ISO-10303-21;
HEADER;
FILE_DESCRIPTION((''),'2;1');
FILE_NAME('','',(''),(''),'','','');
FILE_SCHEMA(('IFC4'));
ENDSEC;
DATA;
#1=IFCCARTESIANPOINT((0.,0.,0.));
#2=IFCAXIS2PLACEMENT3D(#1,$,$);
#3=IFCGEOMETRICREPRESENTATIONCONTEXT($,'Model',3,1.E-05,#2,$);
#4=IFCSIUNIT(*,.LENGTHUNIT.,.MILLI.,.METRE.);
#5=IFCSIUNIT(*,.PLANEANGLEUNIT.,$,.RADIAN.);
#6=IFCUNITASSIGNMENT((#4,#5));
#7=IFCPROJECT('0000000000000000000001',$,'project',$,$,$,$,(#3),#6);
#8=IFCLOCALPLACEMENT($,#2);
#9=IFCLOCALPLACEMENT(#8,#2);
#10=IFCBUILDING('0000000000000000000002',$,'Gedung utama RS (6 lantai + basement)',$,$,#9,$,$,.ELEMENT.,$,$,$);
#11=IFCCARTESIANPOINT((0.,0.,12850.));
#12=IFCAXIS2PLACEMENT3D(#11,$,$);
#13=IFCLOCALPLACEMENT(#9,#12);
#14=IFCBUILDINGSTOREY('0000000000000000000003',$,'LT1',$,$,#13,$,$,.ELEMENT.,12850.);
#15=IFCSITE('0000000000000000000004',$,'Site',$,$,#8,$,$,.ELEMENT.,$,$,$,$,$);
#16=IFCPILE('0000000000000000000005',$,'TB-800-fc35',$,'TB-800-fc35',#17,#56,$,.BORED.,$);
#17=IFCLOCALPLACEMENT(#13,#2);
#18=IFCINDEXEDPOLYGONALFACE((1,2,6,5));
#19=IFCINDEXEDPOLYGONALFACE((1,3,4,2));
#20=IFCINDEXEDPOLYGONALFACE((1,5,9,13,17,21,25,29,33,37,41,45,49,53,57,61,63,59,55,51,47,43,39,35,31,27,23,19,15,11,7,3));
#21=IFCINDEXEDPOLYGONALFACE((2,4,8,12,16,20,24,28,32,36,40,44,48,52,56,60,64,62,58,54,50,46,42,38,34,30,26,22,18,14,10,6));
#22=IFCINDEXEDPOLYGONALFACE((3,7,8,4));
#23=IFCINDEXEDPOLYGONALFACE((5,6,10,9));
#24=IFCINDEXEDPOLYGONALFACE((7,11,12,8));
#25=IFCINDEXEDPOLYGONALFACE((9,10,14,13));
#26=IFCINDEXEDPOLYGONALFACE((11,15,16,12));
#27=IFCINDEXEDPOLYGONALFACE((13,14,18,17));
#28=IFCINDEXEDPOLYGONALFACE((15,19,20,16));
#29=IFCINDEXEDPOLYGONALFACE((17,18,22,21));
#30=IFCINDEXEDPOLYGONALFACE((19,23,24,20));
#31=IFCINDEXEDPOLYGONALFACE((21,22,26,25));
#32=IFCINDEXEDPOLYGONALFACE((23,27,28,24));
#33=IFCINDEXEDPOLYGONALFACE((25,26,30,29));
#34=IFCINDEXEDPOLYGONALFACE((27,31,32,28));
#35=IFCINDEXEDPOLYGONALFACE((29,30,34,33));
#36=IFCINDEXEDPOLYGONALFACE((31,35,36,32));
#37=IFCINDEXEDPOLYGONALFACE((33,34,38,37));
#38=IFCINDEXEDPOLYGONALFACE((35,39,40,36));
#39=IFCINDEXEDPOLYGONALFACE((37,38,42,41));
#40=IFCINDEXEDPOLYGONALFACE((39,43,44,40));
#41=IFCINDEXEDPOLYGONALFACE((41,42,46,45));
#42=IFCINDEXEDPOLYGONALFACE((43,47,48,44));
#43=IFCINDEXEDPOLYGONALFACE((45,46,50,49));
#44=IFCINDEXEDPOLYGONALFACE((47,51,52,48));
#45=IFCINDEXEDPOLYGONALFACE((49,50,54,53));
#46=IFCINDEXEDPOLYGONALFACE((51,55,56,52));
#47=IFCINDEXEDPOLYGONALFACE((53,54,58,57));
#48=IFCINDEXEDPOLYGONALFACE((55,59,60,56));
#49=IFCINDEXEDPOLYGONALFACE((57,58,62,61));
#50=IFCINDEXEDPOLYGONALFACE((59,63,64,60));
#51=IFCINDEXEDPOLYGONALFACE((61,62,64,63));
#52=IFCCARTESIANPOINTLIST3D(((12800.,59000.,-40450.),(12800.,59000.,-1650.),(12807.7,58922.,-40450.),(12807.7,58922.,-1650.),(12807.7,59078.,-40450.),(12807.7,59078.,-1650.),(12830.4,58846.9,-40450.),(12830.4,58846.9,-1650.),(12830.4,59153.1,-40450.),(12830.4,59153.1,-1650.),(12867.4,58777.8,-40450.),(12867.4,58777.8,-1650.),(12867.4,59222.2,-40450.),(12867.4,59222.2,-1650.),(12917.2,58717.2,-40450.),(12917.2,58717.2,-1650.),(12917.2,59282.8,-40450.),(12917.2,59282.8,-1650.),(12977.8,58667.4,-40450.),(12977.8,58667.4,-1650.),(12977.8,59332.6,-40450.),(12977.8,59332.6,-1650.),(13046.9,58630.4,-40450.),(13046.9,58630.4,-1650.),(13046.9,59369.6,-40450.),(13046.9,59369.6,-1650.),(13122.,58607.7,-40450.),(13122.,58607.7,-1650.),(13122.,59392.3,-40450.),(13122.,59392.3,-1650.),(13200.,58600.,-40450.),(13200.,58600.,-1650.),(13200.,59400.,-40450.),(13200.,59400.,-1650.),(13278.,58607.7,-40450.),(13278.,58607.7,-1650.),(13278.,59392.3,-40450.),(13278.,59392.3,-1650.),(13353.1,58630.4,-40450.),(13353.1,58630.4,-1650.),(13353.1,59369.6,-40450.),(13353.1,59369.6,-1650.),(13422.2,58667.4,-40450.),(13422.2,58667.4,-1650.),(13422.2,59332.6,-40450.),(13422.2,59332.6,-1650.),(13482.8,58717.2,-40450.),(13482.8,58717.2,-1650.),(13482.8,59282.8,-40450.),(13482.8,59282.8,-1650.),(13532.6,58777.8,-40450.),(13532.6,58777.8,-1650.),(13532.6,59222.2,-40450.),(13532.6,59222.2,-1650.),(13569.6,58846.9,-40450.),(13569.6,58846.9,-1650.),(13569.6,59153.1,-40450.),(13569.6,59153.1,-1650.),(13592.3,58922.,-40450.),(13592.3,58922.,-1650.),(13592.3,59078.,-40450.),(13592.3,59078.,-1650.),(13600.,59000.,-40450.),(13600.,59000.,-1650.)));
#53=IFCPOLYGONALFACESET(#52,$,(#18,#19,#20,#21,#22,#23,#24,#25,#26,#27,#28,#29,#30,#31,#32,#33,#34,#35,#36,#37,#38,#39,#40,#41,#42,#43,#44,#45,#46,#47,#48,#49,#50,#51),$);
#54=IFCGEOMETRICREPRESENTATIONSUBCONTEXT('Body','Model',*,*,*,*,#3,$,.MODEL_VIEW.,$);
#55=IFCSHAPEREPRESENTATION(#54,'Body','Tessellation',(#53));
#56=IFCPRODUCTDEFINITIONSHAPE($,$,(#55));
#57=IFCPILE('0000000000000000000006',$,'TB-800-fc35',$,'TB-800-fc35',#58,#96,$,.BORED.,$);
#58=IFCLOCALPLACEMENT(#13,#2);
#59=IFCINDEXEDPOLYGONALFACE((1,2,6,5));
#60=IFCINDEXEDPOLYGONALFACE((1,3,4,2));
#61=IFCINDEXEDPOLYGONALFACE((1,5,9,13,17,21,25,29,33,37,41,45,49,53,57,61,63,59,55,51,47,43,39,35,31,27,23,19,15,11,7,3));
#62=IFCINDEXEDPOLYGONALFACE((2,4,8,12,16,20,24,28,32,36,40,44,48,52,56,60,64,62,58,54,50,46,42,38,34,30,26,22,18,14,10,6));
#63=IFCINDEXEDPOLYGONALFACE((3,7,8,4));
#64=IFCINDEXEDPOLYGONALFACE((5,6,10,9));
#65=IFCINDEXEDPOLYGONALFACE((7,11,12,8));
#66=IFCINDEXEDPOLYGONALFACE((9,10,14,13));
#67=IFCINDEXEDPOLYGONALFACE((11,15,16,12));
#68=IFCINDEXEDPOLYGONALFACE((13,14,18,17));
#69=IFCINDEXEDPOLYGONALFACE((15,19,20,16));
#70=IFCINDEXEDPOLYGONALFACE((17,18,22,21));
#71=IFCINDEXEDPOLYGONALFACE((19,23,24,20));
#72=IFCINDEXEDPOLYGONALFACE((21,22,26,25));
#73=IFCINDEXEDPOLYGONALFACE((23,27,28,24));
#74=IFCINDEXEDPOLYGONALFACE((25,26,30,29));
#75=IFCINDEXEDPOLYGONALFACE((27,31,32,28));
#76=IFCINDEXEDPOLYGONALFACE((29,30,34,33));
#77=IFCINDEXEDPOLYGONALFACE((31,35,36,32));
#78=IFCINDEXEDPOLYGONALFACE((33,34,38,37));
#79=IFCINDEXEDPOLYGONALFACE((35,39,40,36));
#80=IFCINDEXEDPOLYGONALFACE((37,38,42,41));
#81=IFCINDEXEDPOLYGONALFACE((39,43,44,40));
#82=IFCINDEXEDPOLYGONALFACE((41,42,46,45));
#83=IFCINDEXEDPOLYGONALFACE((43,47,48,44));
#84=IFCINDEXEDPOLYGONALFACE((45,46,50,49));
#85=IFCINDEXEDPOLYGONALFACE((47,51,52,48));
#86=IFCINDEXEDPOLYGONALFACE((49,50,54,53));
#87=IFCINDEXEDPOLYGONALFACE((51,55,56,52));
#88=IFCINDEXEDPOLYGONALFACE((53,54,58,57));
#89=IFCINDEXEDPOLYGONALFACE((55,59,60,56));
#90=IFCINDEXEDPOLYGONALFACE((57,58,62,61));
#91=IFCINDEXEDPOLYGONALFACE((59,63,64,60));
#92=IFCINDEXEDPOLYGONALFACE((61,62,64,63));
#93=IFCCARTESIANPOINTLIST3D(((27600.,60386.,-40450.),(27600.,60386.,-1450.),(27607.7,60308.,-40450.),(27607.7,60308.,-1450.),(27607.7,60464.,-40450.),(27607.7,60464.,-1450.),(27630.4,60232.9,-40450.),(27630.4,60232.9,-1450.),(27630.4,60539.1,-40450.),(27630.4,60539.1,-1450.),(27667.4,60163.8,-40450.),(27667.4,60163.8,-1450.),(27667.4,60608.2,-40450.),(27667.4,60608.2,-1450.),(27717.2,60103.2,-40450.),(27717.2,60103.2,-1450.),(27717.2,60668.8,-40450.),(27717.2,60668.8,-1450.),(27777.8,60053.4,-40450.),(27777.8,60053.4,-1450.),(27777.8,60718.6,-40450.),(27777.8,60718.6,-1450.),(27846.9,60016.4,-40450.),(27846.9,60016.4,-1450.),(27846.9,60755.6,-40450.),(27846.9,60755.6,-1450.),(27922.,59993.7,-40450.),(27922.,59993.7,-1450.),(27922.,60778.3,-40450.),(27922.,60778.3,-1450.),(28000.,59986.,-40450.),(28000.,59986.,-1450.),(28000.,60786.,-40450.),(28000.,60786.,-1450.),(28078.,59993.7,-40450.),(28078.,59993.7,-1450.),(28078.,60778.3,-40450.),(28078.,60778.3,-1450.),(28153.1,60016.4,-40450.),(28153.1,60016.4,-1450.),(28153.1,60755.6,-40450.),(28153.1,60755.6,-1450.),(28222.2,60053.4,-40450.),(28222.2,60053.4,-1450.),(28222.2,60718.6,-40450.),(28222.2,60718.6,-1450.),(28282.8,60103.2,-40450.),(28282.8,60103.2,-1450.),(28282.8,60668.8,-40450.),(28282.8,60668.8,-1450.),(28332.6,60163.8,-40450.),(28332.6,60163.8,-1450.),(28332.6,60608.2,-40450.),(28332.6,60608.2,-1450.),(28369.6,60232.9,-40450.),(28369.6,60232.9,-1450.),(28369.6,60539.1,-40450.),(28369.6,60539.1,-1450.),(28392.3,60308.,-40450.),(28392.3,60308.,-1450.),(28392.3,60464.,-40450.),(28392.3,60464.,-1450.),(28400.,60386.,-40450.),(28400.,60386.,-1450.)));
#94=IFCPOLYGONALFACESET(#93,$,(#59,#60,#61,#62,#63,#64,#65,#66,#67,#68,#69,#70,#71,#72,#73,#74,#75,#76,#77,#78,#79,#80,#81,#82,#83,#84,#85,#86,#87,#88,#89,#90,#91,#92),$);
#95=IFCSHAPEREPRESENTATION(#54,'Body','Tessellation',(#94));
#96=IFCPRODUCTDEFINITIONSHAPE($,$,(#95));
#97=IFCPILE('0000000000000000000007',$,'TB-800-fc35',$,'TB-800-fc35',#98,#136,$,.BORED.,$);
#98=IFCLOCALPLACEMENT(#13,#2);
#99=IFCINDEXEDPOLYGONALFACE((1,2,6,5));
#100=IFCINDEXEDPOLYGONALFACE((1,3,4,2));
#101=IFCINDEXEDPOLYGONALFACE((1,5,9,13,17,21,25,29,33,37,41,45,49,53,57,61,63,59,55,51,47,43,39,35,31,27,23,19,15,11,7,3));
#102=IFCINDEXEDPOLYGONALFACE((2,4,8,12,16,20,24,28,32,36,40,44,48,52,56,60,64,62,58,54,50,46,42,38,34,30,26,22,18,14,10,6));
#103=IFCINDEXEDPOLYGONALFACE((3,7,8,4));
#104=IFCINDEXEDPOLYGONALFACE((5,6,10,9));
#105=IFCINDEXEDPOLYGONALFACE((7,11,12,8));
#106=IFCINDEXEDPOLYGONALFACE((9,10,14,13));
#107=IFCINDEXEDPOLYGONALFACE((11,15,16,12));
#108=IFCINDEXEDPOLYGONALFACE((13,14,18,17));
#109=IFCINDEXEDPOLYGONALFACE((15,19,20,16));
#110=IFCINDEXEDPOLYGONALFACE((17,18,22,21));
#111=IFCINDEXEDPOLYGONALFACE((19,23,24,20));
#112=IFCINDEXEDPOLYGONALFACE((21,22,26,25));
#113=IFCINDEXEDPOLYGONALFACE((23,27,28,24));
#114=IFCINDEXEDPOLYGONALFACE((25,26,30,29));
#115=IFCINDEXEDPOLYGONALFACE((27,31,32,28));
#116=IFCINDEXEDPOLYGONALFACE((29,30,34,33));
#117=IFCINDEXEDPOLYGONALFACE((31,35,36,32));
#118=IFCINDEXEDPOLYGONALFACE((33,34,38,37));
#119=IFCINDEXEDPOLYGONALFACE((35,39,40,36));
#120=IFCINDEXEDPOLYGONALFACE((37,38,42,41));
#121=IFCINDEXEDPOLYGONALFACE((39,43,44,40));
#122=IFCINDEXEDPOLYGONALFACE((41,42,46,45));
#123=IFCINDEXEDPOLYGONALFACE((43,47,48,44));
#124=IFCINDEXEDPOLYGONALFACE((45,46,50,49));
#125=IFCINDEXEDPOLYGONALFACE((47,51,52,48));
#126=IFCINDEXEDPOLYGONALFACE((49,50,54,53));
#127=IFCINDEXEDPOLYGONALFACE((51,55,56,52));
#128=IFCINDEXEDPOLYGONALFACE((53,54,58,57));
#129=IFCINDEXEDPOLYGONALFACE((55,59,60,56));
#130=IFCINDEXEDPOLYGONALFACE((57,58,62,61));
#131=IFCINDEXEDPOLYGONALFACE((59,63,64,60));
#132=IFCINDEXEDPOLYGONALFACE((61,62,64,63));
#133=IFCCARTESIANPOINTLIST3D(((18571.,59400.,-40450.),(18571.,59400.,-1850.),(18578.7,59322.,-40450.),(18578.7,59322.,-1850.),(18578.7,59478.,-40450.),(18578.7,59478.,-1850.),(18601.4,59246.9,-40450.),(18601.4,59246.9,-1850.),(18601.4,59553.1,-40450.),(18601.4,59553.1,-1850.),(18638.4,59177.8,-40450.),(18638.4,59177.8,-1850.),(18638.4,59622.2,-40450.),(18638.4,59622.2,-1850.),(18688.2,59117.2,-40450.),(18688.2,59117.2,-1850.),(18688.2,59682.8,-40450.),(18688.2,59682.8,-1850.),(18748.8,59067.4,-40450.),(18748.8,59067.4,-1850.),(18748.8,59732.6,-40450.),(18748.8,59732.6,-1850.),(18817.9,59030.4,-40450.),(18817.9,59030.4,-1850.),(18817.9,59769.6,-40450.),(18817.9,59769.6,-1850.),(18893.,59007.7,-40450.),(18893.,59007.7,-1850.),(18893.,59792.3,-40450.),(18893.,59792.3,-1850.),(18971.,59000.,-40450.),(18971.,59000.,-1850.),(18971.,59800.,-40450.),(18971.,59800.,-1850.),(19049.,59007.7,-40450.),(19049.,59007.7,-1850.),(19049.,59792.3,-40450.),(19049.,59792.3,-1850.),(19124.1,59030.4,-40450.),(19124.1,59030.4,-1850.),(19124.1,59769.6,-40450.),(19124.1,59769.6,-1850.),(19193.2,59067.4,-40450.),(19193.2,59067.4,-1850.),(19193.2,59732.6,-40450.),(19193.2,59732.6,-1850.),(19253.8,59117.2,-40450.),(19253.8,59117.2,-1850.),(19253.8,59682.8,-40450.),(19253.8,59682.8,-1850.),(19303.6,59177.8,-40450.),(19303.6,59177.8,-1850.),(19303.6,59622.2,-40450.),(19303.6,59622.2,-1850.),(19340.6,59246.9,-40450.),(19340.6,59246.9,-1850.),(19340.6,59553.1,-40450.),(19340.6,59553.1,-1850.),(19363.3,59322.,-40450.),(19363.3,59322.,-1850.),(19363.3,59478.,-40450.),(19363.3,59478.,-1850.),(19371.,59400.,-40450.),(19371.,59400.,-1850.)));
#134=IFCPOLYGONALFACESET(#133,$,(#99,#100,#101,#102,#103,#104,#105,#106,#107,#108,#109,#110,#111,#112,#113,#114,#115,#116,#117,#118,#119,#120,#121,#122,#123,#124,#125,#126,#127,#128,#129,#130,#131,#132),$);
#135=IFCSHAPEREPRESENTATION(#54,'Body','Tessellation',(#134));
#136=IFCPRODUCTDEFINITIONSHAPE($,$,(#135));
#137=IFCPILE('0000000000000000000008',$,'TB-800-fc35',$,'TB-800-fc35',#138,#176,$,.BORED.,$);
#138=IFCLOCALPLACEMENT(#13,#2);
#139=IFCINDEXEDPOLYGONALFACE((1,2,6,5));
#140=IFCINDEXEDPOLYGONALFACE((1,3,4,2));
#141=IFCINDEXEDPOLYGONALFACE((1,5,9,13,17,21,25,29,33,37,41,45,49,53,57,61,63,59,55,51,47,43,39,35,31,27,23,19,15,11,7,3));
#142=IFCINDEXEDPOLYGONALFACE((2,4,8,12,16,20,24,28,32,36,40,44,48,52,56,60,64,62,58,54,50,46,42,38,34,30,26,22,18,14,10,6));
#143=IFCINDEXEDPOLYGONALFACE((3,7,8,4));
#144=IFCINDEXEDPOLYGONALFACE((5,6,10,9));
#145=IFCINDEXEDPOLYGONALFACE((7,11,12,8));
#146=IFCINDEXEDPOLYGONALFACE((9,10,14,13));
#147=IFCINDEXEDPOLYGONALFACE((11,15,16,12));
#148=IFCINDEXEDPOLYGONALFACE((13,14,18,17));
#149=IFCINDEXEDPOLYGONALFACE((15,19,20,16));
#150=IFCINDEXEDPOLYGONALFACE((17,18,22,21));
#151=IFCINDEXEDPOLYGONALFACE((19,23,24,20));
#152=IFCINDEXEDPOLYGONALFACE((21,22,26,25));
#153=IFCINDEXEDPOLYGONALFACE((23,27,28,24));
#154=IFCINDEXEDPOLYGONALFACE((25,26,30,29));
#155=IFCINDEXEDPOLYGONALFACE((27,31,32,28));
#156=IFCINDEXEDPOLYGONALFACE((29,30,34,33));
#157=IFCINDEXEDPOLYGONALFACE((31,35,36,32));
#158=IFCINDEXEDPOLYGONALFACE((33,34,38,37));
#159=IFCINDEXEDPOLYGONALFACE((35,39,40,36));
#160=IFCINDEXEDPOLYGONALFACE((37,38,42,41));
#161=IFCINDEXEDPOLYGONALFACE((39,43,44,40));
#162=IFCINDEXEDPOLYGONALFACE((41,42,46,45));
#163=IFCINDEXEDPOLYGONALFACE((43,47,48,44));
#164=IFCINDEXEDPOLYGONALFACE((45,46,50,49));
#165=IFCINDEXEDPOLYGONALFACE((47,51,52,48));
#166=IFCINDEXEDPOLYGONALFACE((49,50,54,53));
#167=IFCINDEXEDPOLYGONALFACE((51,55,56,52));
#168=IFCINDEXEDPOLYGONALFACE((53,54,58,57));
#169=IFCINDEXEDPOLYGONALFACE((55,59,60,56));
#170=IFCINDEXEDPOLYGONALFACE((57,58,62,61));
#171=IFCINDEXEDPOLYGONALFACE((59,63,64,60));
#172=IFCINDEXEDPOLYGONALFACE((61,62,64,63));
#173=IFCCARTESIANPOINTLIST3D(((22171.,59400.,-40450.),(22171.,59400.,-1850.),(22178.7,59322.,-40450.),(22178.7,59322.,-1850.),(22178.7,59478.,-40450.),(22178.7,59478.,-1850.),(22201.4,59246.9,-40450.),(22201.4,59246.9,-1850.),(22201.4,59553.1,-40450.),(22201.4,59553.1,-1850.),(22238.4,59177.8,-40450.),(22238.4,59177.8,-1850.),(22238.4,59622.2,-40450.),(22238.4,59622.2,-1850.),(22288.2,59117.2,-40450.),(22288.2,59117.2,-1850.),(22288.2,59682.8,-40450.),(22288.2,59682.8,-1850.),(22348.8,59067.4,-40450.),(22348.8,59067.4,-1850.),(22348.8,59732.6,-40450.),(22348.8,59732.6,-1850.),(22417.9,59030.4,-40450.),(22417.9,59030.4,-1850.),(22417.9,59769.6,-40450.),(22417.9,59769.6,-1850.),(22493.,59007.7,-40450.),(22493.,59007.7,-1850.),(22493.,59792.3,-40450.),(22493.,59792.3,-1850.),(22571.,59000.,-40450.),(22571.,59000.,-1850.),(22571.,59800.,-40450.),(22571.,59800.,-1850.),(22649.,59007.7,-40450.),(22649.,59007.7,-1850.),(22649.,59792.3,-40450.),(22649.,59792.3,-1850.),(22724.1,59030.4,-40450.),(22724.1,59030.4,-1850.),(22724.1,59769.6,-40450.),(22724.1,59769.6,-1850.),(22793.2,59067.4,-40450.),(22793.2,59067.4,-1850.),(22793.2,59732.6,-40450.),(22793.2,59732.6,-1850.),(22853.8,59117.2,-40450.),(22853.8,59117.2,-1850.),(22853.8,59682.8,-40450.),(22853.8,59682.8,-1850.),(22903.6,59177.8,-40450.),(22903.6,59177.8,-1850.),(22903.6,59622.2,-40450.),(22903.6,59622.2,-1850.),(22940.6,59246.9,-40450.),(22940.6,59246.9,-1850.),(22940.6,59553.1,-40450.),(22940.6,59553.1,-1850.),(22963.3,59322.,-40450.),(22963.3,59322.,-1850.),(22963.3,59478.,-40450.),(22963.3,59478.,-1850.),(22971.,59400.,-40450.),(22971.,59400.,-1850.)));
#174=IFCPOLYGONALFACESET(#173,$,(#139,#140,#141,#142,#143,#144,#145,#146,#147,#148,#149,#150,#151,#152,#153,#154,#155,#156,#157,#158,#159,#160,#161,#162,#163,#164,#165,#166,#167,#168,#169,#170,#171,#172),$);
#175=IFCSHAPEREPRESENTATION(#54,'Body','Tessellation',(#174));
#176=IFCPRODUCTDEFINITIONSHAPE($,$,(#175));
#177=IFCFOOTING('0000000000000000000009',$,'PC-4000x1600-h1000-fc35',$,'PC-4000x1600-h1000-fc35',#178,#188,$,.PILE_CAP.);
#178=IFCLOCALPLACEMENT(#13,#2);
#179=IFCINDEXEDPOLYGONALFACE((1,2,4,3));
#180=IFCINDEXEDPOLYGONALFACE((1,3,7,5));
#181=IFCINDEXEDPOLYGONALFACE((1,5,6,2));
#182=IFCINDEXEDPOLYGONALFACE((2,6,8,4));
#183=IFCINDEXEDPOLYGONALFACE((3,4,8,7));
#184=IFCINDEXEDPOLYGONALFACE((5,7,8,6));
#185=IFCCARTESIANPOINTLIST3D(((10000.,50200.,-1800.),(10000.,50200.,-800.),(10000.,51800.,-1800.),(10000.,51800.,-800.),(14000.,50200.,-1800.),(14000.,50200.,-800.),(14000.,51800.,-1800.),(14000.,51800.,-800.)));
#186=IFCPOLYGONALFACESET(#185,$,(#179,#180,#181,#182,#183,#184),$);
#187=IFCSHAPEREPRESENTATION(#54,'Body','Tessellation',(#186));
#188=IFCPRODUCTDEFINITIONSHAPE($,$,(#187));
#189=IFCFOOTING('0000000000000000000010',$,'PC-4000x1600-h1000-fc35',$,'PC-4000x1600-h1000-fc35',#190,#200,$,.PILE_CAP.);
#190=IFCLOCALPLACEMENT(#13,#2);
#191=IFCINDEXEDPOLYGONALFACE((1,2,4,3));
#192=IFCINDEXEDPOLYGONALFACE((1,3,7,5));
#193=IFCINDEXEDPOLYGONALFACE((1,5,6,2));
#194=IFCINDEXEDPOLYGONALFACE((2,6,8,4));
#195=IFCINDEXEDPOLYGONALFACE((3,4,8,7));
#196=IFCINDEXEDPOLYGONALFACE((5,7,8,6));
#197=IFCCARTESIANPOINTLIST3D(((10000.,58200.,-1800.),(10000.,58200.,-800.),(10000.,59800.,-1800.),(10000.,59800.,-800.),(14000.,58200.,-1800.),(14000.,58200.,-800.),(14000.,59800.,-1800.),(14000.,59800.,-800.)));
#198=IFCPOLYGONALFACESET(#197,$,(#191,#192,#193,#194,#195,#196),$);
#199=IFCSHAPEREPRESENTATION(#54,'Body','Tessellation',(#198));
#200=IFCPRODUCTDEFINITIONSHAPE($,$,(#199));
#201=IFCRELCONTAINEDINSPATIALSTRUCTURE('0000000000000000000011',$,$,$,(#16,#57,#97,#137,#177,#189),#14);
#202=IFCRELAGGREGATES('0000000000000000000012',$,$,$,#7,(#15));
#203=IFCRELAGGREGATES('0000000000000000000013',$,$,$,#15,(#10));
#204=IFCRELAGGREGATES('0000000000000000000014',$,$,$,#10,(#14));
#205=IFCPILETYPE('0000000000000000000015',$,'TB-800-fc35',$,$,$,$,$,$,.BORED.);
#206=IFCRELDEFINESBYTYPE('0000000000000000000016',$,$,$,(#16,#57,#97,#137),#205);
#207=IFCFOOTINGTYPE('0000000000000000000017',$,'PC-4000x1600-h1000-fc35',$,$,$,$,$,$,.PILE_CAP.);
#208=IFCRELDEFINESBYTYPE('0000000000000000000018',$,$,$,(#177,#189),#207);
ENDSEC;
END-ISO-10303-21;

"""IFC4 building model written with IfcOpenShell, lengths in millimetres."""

from ifc_helpers import new_model, si_unit, frame, origin, origin_2d, place, context, subcontext, project, spatial, rectangle, circle, extrude, material_profile, profile_set, profile_usage, type_object, element, save


model = new_model("IFC4")

# Units and contexts
model_context = context("Model", 3, precision=1e-05, world=origin())
body_context = subcontext(model_context, "Body", "Model", "MODEL_VIEW")
ifc_project = project(units=[si_unit("LENGTHUNIT", "METRE", prefix="MILLI"), si_unit("PLANEANGLEUNIT", "RADIAN")], contexts=[model_context])

# Site, building, storey
site_placement = place(None, origin())
site = spatial("IfcSite", under=ifc_project, at=site_placement, Name="Site", CompositionType="ELEMENT")
building_placement = place(site_placement, origin())
building = spatial("IfcBuilding", under=site, at=building_placement, Name="Gedung utama RS (6 lantai + basement)", CompositionType="ELEMENT")
storey_placement = place(building_placement, frame((0.0, 0.0, 12850.0)))
storey = spatial("IfcBuildingStorey", under=building, at=storey_placement, Name="LT1", CompositionType="ELEMENT", Elevation=12850.0)

# Piles
ifc_material_profile_1 = material_profile(None, circle(Radius=400.0, at=origin_2d()), Name="TB-800-fc35")
ifc_profile_set_1 = profile_set([ifc_material_profile_1], Name="TB-800-fc35")
ifc_profile_usage_1 = profile_usage(ifc_profile_set_1, cardinal=5)
pile_type = type_object("IfcPileType", Name="TB-800-fc35", PredefinedType="BORED")
pile_1_placement = place(storey_placement, frame((13200.0, 59000.0, -40450.0), z_axis=(0.0, 0.0, 1.0), x_axis=(1.0, 0.0, 0.0)))
element("IfcPile", 1, at=pile_1_placement, inside=storey, type_object=pile_type, material=ifc_profile_usage_1, Name="TB-800-fc35", ObjectType="TB-800-fc35", PredefinedType="BORED", context=body_context, shape_type="SweptSolid", body=[
    extrude(circle(Radius=400.0, at=origin_2d()), origin(), (0.0, 0.0, 1.0), 38800.0),
])
pile_2_placement = place(storey_placement, frame((28000.0, 60386.0, -40450.0), z_axis=(0.0, 0.0, 1.0), x_axis=(1.0, 0.0, 0.0)))
element("IfcPile", 2, at=pile_2_placement, inside=storey, type_object=pile_type, material=ifc_profile_usage_1, Name="TB-800-fc35", ObjectType="TB-800-fc35", PredefinedType="BORED", context=body_context, shape_type="SweptSolid", body=[
    extrude(circle(Radius=400.0, at=origin_2d()), origin(), (0.0, 0.0, 1.0), 39000.0),
])
for number, where, z_axis, x_axis, name in (
    (3, (18971.0, 59400.0, -40450.0), (0.0, 0.0, 1.0), (1.0, 0.0, 0.0), "TB-800-fc35"),
    (4, (22571.0, 59400.0, -40450.0), (0.0, 0.0, 1.0), (1.0, 0.0, 0.0), "TB-800-fc35"),
):
    element("IfcPile", number, at=place(storey_placement, frame(where, z_axis=z_axis, x_axis=x_axis)), inside=storey, type_object=pile_type, material=ifc_profile_usage_1, Name=name, ObjectType="TB-800-fc35", PredefinedType="BORED", context=body_context, shape_type="SweptSolid", body=[
        extrude(circle(Radius=400.0, at=origin_2d()), origin(), (0.0, 0.0, 1.0), 38600.0),
    ])

# Footings
ifc_material_profile_2 = material_profile(None, rectangle(XDim=4000.0, YDim=1600.0, at=origin_2d()), Name="PC-4000x1600-h1000-fc35")
ifc_profile_set_2 = profile_set([ifc_material_profile_2], Name="PC-4000x1600-h1000-fc35")
ifc_profile_usage_2 = profile_usage(ifc_profile_set_2, cardinal=5)
footing_type_1 = type_object("IfcFootingType", Name="PC-4000x1600-h1000-fc35", PredefinedType="PILE_CAP")
for number, where, z_axis, x_axis, name in (
    (5, (12000.0, 51000.0, -1800.0), (0.0, 0.0, 1.0), (1.0, 0.0, 0.0), "PC-4000x1600-h1000-fc35"),
    (6, (12000.0, 59000.0, -1800.0), (0.0, 0.0, 1.0), (1.0, 0.0, 0.0), "PC-4000x1600-h1000-fc35"),
):
    element("IfcFooting", number, at=place(storey_placement, frame(where, z_axis=z_axis, x_axis=x_axis)), inside=storey, type_object=footing_type_1, material=ifc_profile_usage_2, Name=name, ObjectType="PC-4000x1600-h1000-fc35", PredefinedType="PILE_CAP", context=body_context, shape_type="SweptSolid", body=[
        extrude(rectangle(XDim=4000.0, YDim=1600.0, at=origin_2d()), origin(), (0.0, 0.0, 1.0), 1000.0),
    ])

save(model, "model.ifc")
